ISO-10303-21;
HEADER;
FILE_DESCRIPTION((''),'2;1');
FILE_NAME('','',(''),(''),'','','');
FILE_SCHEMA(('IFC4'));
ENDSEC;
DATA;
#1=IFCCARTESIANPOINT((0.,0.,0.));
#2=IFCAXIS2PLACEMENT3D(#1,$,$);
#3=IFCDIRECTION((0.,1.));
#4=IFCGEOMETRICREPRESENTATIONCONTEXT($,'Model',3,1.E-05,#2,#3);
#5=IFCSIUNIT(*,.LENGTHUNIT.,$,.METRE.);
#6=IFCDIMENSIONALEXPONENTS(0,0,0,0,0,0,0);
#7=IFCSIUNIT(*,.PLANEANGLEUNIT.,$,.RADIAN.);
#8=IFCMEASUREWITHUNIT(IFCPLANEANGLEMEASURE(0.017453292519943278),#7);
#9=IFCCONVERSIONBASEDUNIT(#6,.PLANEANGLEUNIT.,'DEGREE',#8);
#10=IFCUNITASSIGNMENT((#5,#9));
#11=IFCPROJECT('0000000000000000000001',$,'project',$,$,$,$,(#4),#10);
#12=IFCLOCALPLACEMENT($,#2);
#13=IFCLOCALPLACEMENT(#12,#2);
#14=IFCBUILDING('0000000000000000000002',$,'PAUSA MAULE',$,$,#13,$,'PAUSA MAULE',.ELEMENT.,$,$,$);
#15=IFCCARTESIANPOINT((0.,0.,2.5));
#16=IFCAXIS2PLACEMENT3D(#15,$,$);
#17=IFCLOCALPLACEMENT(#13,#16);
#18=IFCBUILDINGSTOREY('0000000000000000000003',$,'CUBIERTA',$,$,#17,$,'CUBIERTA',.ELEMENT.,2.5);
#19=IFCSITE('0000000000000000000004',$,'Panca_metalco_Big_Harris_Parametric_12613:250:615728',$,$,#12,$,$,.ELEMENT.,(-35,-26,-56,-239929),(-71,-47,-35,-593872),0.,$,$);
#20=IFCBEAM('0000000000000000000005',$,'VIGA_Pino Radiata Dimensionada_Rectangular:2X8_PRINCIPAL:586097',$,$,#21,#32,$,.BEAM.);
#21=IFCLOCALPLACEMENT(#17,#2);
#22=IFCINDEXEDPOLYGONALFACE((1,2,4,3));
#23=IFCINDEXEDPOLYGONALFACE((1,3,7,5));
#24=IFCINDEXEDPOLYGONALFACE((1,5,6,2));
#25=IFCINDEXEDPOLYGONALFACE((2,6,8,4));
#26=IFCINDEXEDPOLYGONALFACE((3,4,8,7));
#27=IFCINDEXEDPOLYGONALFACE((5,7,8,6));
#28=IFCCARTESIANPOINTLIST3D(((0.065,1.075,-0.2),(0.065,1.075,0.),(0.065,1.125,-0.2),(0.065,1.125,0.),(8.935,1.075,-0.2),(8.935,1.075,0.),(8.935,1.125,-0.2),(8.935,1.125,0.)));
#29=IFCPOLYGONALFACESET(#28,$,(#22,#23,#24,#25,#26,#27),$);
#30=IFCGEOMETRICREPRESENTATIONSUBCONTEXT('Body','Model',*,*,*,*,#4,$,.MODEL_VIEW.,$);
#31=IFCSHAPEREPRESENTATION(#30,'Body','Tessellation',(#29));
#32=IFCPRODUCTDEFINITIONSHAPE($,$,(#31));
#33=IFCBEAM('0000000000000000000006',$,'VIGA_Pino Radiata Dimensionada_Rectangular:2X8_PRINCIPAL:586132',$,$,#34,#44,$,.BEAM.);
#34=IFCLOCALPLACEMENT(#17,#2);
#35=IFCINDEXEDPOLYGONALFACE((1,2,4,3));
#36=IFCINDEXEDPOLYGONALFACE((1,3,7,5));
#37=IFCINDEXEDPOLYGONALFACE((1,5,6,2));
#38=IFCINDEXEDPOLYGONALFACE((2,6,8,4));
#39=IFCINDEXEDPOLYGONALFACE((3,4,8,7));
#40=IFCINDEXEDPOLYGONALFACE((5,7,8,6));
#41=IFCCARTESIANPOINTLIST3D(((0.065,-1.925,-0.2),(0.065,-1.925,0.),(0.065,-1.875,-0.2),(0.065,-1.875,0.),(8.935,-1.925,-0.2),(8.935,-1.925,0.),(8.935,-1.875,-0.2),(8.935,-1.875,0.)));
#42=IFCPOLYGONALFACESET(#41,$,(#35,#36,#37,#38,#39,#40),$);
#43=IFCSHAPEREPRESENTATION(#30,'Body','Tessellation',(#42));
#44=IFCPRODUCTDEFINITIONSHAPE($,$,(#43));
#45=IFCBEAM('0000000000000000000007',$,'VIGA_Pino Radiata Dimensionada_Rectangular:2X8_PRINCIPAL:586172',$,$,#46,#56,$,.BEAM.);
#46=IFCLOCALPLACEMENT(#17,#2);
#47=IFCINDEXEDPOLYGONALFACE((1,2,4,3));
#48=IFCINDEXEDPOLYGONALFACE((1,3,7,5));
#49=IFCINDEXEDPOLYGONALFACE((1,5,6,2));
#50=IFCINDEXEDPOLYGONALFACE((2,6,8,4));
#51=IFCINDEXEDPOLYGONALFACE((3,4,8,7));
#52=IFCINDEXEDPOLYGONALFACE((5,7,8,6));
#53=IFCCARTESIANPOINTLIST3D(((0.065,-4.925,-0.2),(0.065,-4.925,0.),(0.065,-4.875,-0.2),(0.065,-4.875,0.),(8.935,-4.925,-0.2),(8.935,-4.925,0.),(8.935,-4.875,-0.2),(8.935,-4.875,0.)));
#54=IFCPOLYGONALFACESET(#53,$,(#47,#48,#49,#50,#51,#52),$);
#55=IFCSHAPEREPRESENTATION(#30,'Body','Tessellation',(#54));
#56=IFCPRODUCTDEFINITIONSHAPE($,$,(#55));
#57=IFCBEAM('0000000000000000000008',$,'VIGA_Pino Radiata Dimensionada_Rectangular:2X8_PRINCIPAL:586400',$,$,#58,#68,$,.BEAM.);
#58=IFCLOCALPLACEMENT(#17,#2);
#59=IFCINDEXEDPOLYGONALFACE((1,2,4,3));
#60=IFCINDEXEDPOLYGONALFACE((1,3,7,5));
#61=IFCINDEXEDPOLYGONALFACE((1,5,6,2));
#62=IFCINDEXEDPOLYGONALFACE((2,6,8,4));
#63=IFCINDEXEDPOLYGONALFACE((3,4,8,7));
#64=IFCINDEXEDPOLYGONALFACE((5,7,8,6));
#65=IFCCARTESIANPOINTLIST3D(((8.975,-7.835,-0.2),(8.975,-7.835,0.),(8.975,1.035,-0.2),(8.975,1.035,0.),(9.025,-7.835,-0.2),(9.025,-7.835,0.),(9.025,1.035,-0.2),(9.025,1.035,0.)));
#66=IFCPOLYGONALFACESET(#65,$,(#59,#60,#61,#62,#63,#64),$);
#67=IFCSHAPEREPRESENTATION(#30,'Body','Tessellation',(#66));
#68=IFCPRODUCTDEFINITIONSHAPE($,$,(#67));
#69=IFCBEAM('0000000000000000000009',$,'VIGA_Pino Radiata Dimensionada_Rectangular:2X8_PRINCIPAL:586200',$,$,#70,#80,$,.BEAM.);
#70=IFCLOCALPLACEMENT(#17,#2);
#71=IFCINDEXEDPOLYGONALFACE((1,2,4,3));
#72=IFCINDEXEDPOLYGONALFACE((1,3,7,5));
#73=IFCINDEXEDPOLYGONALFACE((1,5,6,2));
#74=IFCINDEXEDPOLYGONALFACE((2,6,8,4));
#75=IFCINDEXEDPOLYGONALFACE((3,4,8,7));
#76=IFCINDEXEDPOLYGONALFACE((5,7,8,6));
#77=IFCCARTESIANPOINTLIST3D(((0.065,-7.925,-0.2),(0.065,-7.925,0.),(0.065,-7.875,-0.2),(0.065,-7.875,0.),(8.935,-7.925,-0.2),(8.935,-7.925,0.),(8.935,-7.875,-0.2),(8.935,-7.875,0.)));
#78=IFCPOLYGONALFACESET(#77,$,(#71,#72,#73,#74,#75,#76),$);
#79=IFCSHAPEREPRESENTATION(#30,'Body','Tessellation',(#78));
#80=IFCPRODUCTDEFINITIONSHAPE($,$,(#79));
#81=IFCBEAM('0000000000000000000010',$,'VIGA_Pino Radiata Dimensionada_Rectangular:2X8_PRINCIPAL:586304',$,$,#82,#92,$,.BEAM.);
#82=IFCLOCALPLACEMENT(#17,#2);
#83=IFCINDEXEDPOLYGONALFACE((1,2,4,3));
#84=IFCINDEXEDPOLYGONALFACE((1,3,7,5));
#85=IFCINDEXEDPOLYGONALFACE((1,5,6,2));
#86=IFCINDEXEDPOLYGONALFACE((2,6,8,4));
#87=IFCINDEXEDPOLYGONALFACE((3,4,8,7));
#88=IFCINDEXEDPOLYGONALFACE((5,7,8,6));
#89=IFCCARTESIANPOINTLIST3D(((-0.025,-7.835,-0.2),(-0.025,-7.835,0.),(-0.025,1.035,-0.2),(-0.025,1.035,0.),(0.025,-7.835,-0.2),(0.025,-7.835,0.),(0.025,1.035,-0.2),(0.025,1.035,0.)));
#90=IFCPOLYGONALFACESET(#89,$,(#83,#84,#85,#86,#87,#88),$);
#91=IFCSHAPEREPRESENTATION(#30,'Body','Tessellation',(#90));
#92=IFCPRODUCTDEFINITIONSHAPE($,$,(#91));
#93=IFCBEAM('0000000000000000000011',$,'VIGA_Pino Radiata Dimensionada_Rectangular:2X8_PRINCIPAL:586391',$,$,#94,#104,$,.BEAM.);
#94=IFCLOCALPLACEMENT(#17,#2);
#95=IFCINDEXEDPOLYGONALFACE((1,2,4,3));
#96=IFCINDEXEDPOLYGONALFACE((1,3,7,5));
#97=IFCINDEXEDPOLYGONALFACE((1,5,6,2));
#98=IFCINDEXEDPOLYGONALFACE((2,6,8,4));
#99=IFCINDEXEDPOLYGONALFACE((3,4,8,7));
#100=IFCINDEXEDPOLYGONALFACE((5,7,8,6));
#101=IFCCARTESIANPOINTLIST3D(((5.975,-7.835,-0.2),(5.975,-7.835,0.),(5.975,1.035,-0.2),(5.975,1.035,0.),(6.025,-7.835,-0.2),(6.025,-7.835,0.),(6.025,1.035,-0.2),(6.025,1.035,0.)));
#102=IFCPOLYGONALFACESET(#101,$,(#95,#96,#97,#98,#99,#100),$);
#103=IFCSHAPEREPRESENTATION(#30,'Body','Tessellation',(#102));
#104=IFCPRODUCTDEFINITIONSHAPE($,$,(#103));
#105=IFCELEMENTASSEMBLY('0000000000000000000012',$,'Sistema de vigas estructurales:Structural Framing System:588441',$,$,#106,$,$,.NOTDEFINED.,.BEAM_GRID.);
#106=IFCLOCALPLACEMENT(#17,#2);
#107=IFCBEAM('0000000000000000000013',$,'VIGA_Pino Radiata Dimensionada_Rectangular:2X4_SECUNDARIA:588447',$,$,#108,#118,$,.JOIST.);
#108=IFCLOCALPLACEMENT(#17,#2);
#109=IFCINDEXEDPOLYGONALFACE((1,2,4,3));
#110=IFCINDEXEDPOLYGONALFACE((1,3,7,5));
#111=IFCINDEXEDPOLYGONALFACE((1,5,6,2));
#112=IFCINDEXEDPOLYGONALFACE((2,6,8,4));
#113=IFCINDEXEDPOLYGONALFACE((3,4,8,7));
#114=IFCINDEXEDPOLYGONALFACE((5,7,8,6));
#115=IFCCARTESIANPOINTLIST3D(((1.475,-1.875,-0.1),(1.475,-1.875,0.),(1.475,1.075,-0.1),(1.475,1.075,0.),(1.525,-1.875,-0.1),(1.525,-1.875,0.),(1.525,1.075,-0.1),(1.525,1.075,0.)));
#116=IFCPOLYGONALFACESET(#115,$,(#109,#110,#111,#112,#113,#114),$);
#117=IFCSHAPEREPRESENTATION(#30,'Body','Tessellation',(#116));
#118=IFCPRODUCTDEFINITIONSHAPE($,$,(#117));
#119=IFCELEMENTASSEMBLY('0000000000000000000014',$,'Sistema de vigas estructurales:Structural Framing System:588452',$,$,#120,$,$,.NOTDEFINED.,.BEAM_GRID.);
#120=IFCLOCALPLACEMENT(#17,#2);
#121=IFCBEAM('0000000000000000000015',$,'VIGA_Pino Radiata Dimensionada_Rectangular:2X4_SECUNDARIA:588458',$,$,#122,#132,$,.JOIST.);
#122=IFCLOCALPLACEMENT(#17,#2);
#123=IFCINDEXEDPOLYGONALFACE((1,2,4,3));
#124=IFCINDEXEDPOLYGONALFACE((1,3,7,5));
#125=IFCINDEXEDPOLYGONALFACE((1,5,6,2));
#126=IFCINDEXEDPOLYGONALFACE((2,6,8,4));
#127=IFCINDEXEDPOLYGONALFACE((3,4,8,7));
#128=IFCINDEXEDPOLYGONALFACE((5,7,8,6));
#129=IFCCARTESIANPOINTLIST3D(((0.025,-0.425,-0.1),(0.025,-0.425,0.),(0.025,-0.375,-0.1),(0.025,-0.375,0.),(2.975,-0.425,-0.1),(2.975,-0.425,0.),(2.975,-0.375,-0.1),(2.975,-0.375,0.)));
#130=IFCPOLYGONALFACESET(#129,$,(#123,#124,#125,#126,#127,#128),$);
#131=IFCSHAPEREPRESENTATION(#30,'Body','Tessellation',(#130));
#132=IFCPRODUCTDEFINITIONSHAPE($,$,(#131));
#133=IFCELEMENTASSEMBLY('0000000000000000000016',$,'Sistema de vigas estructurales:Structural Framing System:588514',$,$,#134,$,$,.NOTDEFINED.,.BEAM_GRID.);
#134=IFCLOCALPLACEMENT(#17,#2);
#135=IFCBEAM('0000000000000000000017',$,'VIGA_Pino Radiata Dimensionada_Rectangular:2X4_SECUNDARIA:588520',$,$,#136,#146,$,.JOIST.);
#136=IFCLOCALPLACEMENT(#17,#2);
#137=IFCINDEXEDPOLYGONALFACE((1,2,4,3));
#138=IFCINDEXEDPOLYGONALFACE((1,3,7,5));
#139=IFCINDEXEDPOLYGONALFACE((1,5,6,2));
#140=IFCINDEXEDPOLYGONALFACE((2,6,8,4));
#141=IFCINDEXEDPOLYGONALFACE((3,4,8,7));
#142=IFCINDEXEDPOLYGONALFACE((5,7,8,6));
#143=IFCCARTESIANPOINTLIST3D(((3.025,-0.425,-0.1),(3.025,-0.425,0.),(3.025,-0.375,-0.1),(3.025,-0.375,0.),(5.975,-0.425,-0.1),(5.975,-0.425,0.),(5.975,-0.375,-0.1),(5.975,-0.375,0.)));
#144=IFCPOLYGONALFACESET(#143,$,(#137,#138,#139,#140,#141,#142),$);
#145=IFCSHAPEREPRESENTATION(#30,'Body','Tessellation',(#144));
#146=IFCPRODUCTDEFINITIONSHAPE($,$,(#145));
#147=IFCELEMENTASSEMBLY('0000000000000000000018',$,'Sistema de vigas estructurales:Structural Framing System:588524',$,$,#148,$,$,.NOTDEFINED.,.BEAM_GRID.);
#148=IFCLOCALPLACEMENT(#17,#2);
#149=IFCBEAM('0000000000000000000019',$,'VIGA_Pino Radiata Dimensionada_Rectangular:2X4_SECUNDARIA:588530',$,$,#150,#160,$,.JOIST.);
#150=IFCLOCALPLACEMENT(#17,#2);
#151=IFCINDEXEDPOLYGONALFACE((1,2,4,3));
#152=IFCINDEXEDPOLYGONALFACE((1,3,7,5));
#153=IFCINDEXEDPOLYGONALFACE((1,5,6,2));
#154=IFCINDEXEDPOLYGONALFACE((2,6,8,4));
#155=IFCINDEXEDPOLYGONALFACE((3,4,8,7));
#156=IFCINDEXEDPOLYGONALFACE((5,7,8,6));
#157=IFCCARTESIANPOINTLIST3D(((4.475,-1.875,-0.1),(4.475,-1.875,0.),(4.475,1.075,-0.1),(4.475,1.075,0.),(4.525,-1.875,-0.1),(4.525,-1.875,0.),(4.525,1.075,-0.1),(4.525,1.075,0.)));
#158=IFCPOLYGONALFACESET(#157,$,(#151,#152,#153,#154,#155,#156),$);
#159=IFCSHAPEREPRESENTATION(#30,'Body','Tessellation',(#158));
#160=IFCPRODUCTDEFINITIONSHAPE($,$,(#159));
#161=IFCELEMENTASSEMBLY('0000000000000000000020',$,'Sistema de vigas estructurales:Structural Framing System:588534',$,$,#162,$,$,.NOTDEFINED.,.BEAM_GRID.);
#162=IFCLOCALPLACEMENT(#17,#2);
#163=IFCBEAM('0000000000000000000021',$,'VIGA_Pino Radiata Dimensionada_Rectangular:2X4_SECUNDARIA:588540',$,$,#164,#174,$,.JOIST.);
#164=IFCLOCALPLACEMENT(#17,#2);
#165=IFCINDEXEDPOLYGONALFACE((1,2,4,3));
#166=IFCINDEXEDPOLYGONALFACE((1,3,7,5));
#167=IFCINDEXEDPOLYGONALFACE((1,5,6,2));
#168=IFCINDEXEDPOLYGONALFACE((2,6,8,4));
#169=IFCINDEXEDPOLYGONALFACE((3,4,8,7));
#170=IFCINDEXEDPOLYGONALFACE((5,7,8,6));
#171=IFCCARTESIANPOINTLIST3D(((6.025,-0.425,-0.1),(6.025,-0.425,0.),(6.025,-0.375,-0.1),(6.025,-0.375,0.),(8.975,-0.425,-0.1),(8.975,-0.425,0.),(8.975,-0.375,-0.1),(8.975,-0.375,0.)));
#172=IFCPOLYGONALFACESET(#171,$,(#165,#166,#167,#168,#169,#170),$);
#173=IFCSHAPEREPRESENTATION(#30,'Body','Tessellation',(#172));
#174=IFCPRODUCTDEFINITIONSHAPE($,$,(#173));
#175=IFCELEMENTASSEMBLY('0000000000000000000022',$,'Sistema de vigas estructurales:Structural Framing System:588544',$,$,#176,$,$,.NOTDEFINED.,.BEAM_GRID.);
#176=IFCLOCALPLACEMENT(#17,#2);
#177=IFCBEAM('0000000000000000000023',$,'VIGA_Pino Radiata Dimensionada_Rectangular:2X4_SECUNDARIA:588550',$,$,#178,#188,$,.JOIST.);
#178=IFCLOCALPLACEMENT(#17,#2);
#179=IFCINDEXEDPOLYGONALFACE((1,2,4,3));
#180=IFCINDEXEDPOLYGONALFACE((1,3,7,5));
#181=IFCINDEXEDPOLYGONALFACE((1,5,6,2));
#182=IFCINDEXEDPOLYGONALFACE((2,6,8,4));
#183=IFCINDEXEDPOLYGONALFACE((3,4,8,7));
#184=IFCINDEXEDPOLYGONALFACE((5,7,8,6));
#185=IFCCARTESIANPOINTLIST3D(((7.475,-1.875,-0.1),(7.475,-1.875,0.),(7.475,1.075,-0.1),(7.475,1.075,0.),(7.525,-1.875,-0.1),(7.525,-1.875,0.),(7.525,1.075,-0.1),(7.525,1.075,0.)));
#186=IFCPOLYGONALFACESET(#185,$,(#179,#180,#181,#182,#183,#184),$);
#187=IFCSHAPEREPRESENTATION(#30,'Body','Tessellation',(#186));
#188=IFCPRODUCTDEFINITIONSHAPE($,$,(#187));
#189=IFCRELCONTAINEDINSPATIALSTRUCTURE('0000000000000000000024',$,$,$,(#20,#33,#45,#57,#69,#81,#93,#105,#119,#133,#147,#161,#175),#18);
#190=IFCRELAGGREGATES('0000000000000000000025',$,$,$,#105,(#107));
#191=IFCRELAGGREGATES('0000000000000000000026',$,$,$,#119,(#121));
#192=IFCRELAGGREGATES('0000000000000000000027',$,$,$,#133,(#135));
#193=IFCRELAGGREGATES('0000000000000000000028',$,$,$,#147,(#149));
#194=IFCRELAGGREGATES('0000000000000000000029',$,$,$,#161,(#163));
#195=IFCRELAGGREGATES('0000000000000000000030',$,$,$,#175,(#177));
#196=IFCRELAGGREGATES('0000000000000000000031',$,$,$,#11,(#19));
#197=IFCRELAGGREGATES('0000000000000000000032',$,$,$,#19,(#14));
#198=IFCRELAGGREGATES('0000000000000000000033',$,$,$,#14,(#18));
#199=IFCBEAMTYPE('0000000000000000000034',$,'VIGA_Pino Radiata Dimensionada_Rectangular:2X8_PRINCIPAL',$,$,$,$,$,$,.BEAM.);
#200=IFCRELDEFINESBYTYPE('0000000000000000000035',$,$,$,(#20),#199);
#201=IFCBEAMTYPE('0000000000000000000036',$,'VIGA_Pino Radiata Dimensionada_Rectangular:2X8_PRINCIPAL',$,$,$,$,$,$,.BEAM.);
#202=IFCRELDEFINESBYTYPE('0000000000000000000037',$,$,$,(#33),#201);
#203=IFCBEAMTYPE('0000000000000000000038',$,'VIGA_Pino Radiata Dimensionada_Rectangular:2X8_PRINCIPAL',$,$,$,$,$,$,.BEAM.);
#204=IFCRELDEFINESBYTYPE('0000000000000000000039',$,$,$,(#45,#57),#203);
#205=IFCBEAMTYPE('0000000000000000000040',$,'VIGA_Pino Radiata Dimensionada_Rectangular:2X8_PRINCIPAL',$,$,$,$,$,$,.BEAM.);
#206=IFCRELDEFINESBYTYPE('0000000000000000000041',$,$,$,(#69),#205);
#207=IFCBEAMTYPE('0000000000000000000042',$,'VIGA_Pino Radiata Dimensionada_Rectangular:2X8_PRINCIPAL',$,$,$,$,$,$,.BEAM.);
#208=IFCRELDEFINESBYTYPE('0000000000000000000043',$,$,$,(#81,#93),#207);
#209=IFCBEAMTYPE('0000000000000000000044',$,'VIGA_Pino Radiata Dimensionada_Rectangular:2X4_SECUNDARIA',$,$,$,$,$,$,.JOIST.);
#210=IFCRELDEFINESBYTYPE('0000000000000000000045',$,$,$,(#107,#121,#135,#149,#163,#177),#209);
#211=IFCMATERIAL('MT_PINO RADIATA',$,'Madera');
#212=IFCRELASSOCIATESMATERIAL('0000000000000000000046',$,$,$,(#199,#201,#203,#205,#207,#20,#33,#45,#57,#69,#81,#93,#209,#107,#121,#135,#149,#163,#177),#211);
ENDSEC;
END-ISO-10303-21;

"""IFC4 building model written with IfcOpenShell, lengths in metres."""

from ifc_helpers import new_model, entity, si_unit, converted_unit, direction, frame, origin, origin_2d_with_axis, place, context, subcontext, project, spatial, rectangle, extrude, source, transform, mapped, material, material_profile, profile_set, profile_usage, type_object, type_shapes, element, aggregate, save


model = new_model("IFC4")

# Units and contexts
model_context = context("Model", 3, precision=1e-05, world=origin(), true_north=direction((0.0, 1.0)))
body_context = subcontext(model_context, "Body", "Model", "MODEL_VIEW")
ifc_project = project(units=[si_unit("LENGTHUNIT", "METRE"), converted_unit("PLANEANGLEUNIT", "DEGREE", entity("IfcPlaneAngleMeasure", 0.017453292519943278), si_unit("PLANEANGLEUNIT", "RADIAN"), dimensions=[0, 0, 0, 0, 0, 0, 0])], contexts=[model_context])

# Site, building, storey
site_placement = place(None, origin())
site = spatial("IfcSite", under=ifc_project, at=site_placement, Name="Panca_metalco_Big_Harris_Parametric_12613:250:615728", CompositionType="ELEMENT", RefLatitude=(-35, -26, -56, -239929), RefLongitude=(-71, -47, -35, -593872), RefElevation=0.0)
building_placement = place(site_placement, origin())
building = spatial("IfcBuilding", under=site, at=building_placement, Name="PAUSA MAULE", LongName="PAUSA MAULE", CompositionType="ELEMENT")
storey_placement = place(building_placement, frame((0.0, 0.0, 2.5)))
storey = spatial("IfcBuildingStorey", under=building, at=storey_placement, Name="CUBIERTA", LongName="CUBIERTA", CompositionType="ELEMENT", Elevation=2.5)

# Beams
ifc_material_1 = material(Name="MT_PINO RADIATA", Category="Madera")
ifc_material_profile_1 = material_profile(ifc_material_1, rectangle(XDim=8.87, YDim=0.05, at=origin_2d_with_axis()), Name="2X8_PRINCIPAL")
ifc_profile_set_1 = profile_set([ifc_material_profile_1], Name="2X8_PRINCIPAL")
ifc_profile_usage_1 = profile_usage(ifc_profile_set_1, cardinal=8)
beam_type_1 = type_object("IfcBeamType", Name="VIGA_Pino Radiata Dimensionada_Rectangular:2X8_PRINCIPAL", PredefinedType="BEAM", material=ifc_profile_set_1)
shared_shape_1 = source(origin(), body_context, "Body", "SweptSolid", [
    extrude(rectangle(XDim=8.87, YDim=0.05, at=origin_2d_with_axis()), frame((0.0, 0.0, -0.1), z_axis=(0.0, 0.0, 1.0), x_axis=(-1.0, 0.0, 0.0)), (0.0, 0.0, 1.0), 0.2),
])
type_shapes(beam_type_1, [shared_shape_1])
beam_1_placement = place(storey_placement, frame((4.5, 1.1, -0.1)))
element("IfcBeam", 1, at=beam_1_placement, inside=storey, type_object=beam_type_1, material=ifc_profile_usage_1, Name="VIGA_Pino Radiata Dimensionada_Rectangular:2X8_PRINCIPAL:586097", PredefinedType="BEAM", context=body_context, shape_type="MappedRepresentation", body=[
    mapped(shared_shape_1, transform((0.0, 0.0, 0.0), scale=1.0)),
])
beam_type_2 = type_object("IfcBeamType", Name="VIGA_Pino Radiata Dimensionada_Rectangular:2X8_PRINCIPAL", PredefinedType="BEAM", material=ifc_profile_set_1)
shared_shape_2 = source(origin(), body_context, "Body", "SweptSolid", [
    extrude(rectangle(XDim=8.87, YDim=0.05, at=origin_2d_with_axis()), frame((0.0, 0.0, -0.1), z_axis=(0.0, 0.0, 1.0), x_axis=(-1.0, 0.0, 0.0)), (0.0, 0.0, 1.0), 0.2),
])
type_shapes(beam_type_2, [shared_shape_2])
beam_2_placement = place(storey_placement, frame((4.5, -1.9, -0.1)))
element("IfcBeam", 2, at=beam_2_placement, inside=storey, type_object=beam_type_2, material=ifc_profile_usage_1, Name="VIGA_Pino Radiata Dimensionada_Rectangular:2X8_PRINCIPAL:586132", PredefinedType="BEAM", context=body_context, shape_type="MappedRepresentation", body=[
    mapped(shared_shape_2, transform((0.0, 0.0, 0.0), scale=1.0)),
])
beam_type_3 = type_object("IfcBeamType", Name="VIGA_Pino Radiata Dimensionada_Rectangular:2X8_PRINCIPAL", PredefinedType="BEAM", material=ifc_profile_set_1)
shared_shape_3 = source(origin(), body_context, "Body", "SweptSolid", [
    extrude(rectangle(XDim=8.87, YDim=0.05, at=origin_2d_with_axis()), frame((-0.0325, 0.0, -0.1), z_axis=(0.0, 0.0, 1.0), x_axis=(-1.0, 0.0, 0.0)), (0.0, 0.0, 1.0), 0.2),
])
type_shapes(beam_type_3, [shared_shape_3])
beam_3_placement = place(storey_placement, frame((4.5325, -4.9, -0.1)))
element("IfcBeam", 3, at=beam_3_placement, inside=storey, type_object=beam_type_3, material=ifc_profile_usage_1, Name="VIGA_Pino Radiata Dimensionada_Rectangular:2X8_PRINCIPAL:586172", PredefinedType="BEAM", context=body_context, shape_type="MappedRepresentation", body=[
    mapped(shared_shape_3, transform((0.0, 0.0, 0.0), scale=1.0)),
])
beam_4_placement = place(storey_placement, frame((9.0, -3.3675, -0.1), z_axis=(0.0, 0.0, 1.0), x_axis=(0.0, 1.0, 0.0)))
element("IfcBeam", 4, at=beam_4_placement, inside=storey, type_object=beam_type_3, material=ifc_profile_usage_1, Name="VIGA_Pino Radiata Dimensionada_Rectangular:2X8_PRINCIPAL:586400", PredefinedType="BEAM", context=body_context, shape_type="MappedRepresentation", body=[
    mapped(shared_shape_3, transform((0.0, 0.0, 0.0), scale=1.0)),
])
beam_type_4 = type_object("IfcBeamType", Name="VIGA_Pino Radiata Dimensionada_Rectangular:2X8_PRINCIPAL", PredefinedType="BEAM", material=ifc_profile_set_1)
shared_shape_4 = source(origin(), body_context, "Body", "SweptSolid", [
    extrude(rectangle(XDim=8.87, YDim=0.05, at=origin_2d_with_axis()), frame((-0.01, 0.0, -0.1), z_axis=(0.0, 0.0, 1.0), x_axis=(-1.0, 0.0, 0.0)), (0.0, 0.0, 1.0), 0.2),
])
type_shapes(beam_type_4, [shared_shape_4])
beam_5_placement = place(storey_placement, frame((4.51, -7.9, -0.1)))
element("IfcBeam", 5, at=beam_5_placement, inside=storey, type_object=beam_type_4, material=ifc_profile_usage_1, Name="VIGA_Pino Radiata Dimensionada_Rectangular:2X8_PRINCIPAL:586200", PredefinedType="BEAM", context=body_context, shape_type="MappedRepresentation", body=[
    mapped(shared_shape_4, transform((0.0, 0.0, 0.0), scale=1.0)),
])
beam_type_5 = type_object("IfcBeamType", Name="VIGA_Pino Radiata Dimensionada_Rectangular:2X8_PRINCIPAL", PredefinedType="BEAM", material=ifc_profile_set_1)
shared_shape_5 = source(origin(), body_context, "Body", "SweptSolid", [
    extrude(rectangle(XDim=8.87, YDim=0.05, at=origin_2d_with_axis()), frame((-0.045, 0.0, -0.1), z_axis=(0.0, 0.0, 1.0), x_axis=(-1.0, 0.0, 0.0)), (0.0, 0.0, 1.0), 0.2),
])
type_shapes(beam_type_5, [shared_shape_5])
for number, where, z_axis, x_axis, name in (
    (6, (0.0, -3.355, -0.1), (0.0, 0.0, 1.0), (0.0, 1.0, 0.0), "VIGA_Pino Radiata Dimensionada_Rectangular:2X8_PRINCIPAL:586304"),
    (7, (6.0, -3.355, -0.1), (0.0, 0.0, 1.0), (0.0, 1.0, 0.0), "VIGA_Pino Radiata Dimensionada_Rectangular:2X8_PRINCIPAL:586391"),
):
    element("IfcBeam", number, at=place(storey_placement, frame(where, z_axis=z_axis, x_axis=x_axis)), inside=storey, type_object=beam_type_5, material=ifc_profile_usage_1, Name=name, PredefinedType="BEAM", context=body_context, shape_type="MappedRepresentation", body=[
        mapped(shared_shape_5, transform((0.0, 0.0, 0.0), scale=1.0)),
    ])

# Element assemblies, beams
assembly_1_placement = place(storey_placement, origin())
assembly_1 = element("IfcElementAssembly", 8, at=assembly_1_placement, inside=storey, Name="Sistema de vigas estructurales:Structural Framing System:588441", AssemblyPlace="NOTDEFINED", PredefinedType="BEAM_GRID")
ifc_material_profile_2 = material_profile(ifc_material_1, rectangle(XDim=2.95, YDim=0.05, at=origin_2d_with_axis()), Name="2X4_SECUNDARIA")
ifc_profile_set_2 = profile_set([ifc_material_profile_2], Name="2X4_SECUNDARIA")
ifc_profile_usage_2 = profile_usage(ifc_profile_set_2, cardinal=8)
beam_type_6 = type_object("IfcBeamType", Name="VIGA_Pino Radiata Dimensionada_Rectangular:2X4_SECUNDARIA", PredefinedType="JOIST", material=ifc_profile_set_2)
shared_shape_6 = source(origin(), body_context, "Body", "SweptSolid", [
    extrude(rectangle(XDim=2.95, YDim=0.05, at=origin_2d_with_axis()), frame((0.0, 0.0, -0.05), z_axis=(0.0, 0.0, 1.0), x_axis=(-1.0, 0.0, 0.0)), (0.0, 0.0, 1.0), 0.1),
])
type_shapes(beam_type_6, [shared_shape_6])
beam_6_placement = place(assembly_1_placement, frame((1.5, -0.4, -0.05), z_axis=(0.0, 0.0, 1.0), x_axis=(0.0, 1.0, 0.0)))
beam_6 = element("IfcBeam", 9, at=beam_6_placement, type_object=beam_type_6, material=ifc_profile_usage_2, Name="VIGA_Pino Radiata Dimensionada_Rectangular:2X4_SECUNDARIA:588447", PredefinedType="JOIST", context=body_context, shape_type="MappedRepresentation", body=[
    mapped(shared_shape_6, transform((0.0, 0.0, 0.0), scale=1.0)),
])
aggregate(assembly_1, [beam_6])
assembly_2_placement = place(storey_placement, origin())
assembly_2 = element("IfcElementAssembly", 10, at=assembly_2_placement, inside=storey, Name="Sistema de vigas estructurales:Structural Framing System:588452", AssemblyPlace="NOTDEFINED", PredefinedType="BEAM_GRID")
beam_7_placement = place(assembly_2_placement, frame((1.5, -0.4, -0.05)))
beam_7 = element("IfcBeam", 11, at=beam_7_placement, type_object=beam_type_6, material=ifc_profile_usage_2, Name="VIGA_Pino Radiata Dimensionada_Rectangular:2X4_SECUNDARIA:588458", PredefinedType="JOIST", context=body_context, shape_type="MappedRepresentation", body=[
    mapped(shared_shape_6, transform((0.0, 0.0, 0.0), scale=1.0)),
])
aggregate(assembly_2, [beam_7])
assembly_3_placement = place(storey_placement, origin())
assembly_3 = element("IfcElementAssembly", 12, at=assembly_3_placement, inside=storey, Name="Sistema de vigas estructurales:Structural Framing System:588514", AssemblyPlace="NOTDEFINED", PredefinedType="BEAM_GRID")
beam_8_placement = place(assembly_3_placement, frame((4.5, -0.4, -0.05)))
beam_8 = element("IfcBeam", 13, at=beam_8_placement, type_object=beam_type_6, material=ifc_profile_usage_2, Name="VIGA_Pino Radiata Dimensionada_Rectangular:2X4_SECUNDARIA:588520", PredefinedType="JOIST", context=body_context, shape_type="MappedRepresentation", body=[
    mapped(shared_shape_6, transform((0.0, 0.0, 0.0), scale=1.0)),
])
aggregate(assembly_3, [beam_8])
assembly_4_placement = place(storey_placement, origin())
assembly_4 = element("IfcElementAssembly", 14, at=assembly_4_placement, inside=storey, Name="Sistema de vigas estructurales:Structural Framing System:588524", AssemblyPlace="NOTDEFINED", PredefinedType="BEAM_GRID")
beam_9_placement = place(assembly_4_placement, frame((4.5, -0.4, -0.05), z_axis=(0.0, 0.0, 1.0), x_axis=(0.0, 1.0, 0.0)))
beam_9 = element("IfcBeam", 15, at=beam_9_placement, type_object=beam_type_6, material=ifc_profile_usage_2, Name="VIGA_Pino Radiata Dimensionada_Rectangular:2X4_SECUNDARIA:588530", PredefinedType="JOIST", context=body_context, shape_type="MappedRepresentation", body=[
    mapped(shared_shape_6, transform((0.0, 0.0, 0.0), scale=1.0)),
])
aggregate(assembly_4, [beam_9])
assembly_5_placement = place(storey_placement, origin())
assembly_5 = element("IfcElementAssembly", 16, at=assembly_5_placement, inside=storey, Name="Sistema de vigas estructurales:Structural Framing System:588534", AssemblyPlace="NOTDEFINED", PredefinedType="BEAM_GRID")
beam_10_placement = place(assembly_5_placement, frame((7.5, -0.4, -0.05)))
beam_10 = element("IfcBeam", 17, at=beam_10_placement, type_object=beam_type_6, material=ifc_profile_usage_2, Name="VIGA_Pino Radiata Dimensionada_Rectangular:2X4_SECUNDARIA:588540", PredefinedType="JOIST", context=body_context, shape_type="MappedRepresentation", body=[
    mapped(shared_shape_6, transform((0.0, 0.0, 0.0), scale=1.0)),
])
aggregate(assembly_5, [beam_10])
assembly_6_placement = place(storey_placement, origin())
assembly_6 = element("IfcElementAssembly", 18, at=assembly_6_placement, inside=storey, Name="Sistema de vigas estructurales:Structural Framing System:588544", AssemblyPlace="NOTDEFINED", PredefinedType="BEAM_GRID")
beam_11_placement = place(assembly_6_placement, frame((7.5, -0.4, -0.05), z_axis=(0.0, 0.0, 1.0), x_axis=(0.0, 1.0, 0.0)))
beam_11 = element("IfcBeam", 19, at=beam_11_placement, type_object=beam_type_6, material=ifc_profile_usage_2, Name="VIGA_Pino Radiata Dimensionada_Rectangular:2X4_SECUNDARIA:588550", PredefinedType="JOIST", context=body_context, shape_type="MappedRepresentation", body=[
    mapped(shared_shape_6, transform((0.0, 0.0, 0.0), scale=1.0)),
])
aggregate(assembly_6, [beam_11])

save(model, "model.ifc")
